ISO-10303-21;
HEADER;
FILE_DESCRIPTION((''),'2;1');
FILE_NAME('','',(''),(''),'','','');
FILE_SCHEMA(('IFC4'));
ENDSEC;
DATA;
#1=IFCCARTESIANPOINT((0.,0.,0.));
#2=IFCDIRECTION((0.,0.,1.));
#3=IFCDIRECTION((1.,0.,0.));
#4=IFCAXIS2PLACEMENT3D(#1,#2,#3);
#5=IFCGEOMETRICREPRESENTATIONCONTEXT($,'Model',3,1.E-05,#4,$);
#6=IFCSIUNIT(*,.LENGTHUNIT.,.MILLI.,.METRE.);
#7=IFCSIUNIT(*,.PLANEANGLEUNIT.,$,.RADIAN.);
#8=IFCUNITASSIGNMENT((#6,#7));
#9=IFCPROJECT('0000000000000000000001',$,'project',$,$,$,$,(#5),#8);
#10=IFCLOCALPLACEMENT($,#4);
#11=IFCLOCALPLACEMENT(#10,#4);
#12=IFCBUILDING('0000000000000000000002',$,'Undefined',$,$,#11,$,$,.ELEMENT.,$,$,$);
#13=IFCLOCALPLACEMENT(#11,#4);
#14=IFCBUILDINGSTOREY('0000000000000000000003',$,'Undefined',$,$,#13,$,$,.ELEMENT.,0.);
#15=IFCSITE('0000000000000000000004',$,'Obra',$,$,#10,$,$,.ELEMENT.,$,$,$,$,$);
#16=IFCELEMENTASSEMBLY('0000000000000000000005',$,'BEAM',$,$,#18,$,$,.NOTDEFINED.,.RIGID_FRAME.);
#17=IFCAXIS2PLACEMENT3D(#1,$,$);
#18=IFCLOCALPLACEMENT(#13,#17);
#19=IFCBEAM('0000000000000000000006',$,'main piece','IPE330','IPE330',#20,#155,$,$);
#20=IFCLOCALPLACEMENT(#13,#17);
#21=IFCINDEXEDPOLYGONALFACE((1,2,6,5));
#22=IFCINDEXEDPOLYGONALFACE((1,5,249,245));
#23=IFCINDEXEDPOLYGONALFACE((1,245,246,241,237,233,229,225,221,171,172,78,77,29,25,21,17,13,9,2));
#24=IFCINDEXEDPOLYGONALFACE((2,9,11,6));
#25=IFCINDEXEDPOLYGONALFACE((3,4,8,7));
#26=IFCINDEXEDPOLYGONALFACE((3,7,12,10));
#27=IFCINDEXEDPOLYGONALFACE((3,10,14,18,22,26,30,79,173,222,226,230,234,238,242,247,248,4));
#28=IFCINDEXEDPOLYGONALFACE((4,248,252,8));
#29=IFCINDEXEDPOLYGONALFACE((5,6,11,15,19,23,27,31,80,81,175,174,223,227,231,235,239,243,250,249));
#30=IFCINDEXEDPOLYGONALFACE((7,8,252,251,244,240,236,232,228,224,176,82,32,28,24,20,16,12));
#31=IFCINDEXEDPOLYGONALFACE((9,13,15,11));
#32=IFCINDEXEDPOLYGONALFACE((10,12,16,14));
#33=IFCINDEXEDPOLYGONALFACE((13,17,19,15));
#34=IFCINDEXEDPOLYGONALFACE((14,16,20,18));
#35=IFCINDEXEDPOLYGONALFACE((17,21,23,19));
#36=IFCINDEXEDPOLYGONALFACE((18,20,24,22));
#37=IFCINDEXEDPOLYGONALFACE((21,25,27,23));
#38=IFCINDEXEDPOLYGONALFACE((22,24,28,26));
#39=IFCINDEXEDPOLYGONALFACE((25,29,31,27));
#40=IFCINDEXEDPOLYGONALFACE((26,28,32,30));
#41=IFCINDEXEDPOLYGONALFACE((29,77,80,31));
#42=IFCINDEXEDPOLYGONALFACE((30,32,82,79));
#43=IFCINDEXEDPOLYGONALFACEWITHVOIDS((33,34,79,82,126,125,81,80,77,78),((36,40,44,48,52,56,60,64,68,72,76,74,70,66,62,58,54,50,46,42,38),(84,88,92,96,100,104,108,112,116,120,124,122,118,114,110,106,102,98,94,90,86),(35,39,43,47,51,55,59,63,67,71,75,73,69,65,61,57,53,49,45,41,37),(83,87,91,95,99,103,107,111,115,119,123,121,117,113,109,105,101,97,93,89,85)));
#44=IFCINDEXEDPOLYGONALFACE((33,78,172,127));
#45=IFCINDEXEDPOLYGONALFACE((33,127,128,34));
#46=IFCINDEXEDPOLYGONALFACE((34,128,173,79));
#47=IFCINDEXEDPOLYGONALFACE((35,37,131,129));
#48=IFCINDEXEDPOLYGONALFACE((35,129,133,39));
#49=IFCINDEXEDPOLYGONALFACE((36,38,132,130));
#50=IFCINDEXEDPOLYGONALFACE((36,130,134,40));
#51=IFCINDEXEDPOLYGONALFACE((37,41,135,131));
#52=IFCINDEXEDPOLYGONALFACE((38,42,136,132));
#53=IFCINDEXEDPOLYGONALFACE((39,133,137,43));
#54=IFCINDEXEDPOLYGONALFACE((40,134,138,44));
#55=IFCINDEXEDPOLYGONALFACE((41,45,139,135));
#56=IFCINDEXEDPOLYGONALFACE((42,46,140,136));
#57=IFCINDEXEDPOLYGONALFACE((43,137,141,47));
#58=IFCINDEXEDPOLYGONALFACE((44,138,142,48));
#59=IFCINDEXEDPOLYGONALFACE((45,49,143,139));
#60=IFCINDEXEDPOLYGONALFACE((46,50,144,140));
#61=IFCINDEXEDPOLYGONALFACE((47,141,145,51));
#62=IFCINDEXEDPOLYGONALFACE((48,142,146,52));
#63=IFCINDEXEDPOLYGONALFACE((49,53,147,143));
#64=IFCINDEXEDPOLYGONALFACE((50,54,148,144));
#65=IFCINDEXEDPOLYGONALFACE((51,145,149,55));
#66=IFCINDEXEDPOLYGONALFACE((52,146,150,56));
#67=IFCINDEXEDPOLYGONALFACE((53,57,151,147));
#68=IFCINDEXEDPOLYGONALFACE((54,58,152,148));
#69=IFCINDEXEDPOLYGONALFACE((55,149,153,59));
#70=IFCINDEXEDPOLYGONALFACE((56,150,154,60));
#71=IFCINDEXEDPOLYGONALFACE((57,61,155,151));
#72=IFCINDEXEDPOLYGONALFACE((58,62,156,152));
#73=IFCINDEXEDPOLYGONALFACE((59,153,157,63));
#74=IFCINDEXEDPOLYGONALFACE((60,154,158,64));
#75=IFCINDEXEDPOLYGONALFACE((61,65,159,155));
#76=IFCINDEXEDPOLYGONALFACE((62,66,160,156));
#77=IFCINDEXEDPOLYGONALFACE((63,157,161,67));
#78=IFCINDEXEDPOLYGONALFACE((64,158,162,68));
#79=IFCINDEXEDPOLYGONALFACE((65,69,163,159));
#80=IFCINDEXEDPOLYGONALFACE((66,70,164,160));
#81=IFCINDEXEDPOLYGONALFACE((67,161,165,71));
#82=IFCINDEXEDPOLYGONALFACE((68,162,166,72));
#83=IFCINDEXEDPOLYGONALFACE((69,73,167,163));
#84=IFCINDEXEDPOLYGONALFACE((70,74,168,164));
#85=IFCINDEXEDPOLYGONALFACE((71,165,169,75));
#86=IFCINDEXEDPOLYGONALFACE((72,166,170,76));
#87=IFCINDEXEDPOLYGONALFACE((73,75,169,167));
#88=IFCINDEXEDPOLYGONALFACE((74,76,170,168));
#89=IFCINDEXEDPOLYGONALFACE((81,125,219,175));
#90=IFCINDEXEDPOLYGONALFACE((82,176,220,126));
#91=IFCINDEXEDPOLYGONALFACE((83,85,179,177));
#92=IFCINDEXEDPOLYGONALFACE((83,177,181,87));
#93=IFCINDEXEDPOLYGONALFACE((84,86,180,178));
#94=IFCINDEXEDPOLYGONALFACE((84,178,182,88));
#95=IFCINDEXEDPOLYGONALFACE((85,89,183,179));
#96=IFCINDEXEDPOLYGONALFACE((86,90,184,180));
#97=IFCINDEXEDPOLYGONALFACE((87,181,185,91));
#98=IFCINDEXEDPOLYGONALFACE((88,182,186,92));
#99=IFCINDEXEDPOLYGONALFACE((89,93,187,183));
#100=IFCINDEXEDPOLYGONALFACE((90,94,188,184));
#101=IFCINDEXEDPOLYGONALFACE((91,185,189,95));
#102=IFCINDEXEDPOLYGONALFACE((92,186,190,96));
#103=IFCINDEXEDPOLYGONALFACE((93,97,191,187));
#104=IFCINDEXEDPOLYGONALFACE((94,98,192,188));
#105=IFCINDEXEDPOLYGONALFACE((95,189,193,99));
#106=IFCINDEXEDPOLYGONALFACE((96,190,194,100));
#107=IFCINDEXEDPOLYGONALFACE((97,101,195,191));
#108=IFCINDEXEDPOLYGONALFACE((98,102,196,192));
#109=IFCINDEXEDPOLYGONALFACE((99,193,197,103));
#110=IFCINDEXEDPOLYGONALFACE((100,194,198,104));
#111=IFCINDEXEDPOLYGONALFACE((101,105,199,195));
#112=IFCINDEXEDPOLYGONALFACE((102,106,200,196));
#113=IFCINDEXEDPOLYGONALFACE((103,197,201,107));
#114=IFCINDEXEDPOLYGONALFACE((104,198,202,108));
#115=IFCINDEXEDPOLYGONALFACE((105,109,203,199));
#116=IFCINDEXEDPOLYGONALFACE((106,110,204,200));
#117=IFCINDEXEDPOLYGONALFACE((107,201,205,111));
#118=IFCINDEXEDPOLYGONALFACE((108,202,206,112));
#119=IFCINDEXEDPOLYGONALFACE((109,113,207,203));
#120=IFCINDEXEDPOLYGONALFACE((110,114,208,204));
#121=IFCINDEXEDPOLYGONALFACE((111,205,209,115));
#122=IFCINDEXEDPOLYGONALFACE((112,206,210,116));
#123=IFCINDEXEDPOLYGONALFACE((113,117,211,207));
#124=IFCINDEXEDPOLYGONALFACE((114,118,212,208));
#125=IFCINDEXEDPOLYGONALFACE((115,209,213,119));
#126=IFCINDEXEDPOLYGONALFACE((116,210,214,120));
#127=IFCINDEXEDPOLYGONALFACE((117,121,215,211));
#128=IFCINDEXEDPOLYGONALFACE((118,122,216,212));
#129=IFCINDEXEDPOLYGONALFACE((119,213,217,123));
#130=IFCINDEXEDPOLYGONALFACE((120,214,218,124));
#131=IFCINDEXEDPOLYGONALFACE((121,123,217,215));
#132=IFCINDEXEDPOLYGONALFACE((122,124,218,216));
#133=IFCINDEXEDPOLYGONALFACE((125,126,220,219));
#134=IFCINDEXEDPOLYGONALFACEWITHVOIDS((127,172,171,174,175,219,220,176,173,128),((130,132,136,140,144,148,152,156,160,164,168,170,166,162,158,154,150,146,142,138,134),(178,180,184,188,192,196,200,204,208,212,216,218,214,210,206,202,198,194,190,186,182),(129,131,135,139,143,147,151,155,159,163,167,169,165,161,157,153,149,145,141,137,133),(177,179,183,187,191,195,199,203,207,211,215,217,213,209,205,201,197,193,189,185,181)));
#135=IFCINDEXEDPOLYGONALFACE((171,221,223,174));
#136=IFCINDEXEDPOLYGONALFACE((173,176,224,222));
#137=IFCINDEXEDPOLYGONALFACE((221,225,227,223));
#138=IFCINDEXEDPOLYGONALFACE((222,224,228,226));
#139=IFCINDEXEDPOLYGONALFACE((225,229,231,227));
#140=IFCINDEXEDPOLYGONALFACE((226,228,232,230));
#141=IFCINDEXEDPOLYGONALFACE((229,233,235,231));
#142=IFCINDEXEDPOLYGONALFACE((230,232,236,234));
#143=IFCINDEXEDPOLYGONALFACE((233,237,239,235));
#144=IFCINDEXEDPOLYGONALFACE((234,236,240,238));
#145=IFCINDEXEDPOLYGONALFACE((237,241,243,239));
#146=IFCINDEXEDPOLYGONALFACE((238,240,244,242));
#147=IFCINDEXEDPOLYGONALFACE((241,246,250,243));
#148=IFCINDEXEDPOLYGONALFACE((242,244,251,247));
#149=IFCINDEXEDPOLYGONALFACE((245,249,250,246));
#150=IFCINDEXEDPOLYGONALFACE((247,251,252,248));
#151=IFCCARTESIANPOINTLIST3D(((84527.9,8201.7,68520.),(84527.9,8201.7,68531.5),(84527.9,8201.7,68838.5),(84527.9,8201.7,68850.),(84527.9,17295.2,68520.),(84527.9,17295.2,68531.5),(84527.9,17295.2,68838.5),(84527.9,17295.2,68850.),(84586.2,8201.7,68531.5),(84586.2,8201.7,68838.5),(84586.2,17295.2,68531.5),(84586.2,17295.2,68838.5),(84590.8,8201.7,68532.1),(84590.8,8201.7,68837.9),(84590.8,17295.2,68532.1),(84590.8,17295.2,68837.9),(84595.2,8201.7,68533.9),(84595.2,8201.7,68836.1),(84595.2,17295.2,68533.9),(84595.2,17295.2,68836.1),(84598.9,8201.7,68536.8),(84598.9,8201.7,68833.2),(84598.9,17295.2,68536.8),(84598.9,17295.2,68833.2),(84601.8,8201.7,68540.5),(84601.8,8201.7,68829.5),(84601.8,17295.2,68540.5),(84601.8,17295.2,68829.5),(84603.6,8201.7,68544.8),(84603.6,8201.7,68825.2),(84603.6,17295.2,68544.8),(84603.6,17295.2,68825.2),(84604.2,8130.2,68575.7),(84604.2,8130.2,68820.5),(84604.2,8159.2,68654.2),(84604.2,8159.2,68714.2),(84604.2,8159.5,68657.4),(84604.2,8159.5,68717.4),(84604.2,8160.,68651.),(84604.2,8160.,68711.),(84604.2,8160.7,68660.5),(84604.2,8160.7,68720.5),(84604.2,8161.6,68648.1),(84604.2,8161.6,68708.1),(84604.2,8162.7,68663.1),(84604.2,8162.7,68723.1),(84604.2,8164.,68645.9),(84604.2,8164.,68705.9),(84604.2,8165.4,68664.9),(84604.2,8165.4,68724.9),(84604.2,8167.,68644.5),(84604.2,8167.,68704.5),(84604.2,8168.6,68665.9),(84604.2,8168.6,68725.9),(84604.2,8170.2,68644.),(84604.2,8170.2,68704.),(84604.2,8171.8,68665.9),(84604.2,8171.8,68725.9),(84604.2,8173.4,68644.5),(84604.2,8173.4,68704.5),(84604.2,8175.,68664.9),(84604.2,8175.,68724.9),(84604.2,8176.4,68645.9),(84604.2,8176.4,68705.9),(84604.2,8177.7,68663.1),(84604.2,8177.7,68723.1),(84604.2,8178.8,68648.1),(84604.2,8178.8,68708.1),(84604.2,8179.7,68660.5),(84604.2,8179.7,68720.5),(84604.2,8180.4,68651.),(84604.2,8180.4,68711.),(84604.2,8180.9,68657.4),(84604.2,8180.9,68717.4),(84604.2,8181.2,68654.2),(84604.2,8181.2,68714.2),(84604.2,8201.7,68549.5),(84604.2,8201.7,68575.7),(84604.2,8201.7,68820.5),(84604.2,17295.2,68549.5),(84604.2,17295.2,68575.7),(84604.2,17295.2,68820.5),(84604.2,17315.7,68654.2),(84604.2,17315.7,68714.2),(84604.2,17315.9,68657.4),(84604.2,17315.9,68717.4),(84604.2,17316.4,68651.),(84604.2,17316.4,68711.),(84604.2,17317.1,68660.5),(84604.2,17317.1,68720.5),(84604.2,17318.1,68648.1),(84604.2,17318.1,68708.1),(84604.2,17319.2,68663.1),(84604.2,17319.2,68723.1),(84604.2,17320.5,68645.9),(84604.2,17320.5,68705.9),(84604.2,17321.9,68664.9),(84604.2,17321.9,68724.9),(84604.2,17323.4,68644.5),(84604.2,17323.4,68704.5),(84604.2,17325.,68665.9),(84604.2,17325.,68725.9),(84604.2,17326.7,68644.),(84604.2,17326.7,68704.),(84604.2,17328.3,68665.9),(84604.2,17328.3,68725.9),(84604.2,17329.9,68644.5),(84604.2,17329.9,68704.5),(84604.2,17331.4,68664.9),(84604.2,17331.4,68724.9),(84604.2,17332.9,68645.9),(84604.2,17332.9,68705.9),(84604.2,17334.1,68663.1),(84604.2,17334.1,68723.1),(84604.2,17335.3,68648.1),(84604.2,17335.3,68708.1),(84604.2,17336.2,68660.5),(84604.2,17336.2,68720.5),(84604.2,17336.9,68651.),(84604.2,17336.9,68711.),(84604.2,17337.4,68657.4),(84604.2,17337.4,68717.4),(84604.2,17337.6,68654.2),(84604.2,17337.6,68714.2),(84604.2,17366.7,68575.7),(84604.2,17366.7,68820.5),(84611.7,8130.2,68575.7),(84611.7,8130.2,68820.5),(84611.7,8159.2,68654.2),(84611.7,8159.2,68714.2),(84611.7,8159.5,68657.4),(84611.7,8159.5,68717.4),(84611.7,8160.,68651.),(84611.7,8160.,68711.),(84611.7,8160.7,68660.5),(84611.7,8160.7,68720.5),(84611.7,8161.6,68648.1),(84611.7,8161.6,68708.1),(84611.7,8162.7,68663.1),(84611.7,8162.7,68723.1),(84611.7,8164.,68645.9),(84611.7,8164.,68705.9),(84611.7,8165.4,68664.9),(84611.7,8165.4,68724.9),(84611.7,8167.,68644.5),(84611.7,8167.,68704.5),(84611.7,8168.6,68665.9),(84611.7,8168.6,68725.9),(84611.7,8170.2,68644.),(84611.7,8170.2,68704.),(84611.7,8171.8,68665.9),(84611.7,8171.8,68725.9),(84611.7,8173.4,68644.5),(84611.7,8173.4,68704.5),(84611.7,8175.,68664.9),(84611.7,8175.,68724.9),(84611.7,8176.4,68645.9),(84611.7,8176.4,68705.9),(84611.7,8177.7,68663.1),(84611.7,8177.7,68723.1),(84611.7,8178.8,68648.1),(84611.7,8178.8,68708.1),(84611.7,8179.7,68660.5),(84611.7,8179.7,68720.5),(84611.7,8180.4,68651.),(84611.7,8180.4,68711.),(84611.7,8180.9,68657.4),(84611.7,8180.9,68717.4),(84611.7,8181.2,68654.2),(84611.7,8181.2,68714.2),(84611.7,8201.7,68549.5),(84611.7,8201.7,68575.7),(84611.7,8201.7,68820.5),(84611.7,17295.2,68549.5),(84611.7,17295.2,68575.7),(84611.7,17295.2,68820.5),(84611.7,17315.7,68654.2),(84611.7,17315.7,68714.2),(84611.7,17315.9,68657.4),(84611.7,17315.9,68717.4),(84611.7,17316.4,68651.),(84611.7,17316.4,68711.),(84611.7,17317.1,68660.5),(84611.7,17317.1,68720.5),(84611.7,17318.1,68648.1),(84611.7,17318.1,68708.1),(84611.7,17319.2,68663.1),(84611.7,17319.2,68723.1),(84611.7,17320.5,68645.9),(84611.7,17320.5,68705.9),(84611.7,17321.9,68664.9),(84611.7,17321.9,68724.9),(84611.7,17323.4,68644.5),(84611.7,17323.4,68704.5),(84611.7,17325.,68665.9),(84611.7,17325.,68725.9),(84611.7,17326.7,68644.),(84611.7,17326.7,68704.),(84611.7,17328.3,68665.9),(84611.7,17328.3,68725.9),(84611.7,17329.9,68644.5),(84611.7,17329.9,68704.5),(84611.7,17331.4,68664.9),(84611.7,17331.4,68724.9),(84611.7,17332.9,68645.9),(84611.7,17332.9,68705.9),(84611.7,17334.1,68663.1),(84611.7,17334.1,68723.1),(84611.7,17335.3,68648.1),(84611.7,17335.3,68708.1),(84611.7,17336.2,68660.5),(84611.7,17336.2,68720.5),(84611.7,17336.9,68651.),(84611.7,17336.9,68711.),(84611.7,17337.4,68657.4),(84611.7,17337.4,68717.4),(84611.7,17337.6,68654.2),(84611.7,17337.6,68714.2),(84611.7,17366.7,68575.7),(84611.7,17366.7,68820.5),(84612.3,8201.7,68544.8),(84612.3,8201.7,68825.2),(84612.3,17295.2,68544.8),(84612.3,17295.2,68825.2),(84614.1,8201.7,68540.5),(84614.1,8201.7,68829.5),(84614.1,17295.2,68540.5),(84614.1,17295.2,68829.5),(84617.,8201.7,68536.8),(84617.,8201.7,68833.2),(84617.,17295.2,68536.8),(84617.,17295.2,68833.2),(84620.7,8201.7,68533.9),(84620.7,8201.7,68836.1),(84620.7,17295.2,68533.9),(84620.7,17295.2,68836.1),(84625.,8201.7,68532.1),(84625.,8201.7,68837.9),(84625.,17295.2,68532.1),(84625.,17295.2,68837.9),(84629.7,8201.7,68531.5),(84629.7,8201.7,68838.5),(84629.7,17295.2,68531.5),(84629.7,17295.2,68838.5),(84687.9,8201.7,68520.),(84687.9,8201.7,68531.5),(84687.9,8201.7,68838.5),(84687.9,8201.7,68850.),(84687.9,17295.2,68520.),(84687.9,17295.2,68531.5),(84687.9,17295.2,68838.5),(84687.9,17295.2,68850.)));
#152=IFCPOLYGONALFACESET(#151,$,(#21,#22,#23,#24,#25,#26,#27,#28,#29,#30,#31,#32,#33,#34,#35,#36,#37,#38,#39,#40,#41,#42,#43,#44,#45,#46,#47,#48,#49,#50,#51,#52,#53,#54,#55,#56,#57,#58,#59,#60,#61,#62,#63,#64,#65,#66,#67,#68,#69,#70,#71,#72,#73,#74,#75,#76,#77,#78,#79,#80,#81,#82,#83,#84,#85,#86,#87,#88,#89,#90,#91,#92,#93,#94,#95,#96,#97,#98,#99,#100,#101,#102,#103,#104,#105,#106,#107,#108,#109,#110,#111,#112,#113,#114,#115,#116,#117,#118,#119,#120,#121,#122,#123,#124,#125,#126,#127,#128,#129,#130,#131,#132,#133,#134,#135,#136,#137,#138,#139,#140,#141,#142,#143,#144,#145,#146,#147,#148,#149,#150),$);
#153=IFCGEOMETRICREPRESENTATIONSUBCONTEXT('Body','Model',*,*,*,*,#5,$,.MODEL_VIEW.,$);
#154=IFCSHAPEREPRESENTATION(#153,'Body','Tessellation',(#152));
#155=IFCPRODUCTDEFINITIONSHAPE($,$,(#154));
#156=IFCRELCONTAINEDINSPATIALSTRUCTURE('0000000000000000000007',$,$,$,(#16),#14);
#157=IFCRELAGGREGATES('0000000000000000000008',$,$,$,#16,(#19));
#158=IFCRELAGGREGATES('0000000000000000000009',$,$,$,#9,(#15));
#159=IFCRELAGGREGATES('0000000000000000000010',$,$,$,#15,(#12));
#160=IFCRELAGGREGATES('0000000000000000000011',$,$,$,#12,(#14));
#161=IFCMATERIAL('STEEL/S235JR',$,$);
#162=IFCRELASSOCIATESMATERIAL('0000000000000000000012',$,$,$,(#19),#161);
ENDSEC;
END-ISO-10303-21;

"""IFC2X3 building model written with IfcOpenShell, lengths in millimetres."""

from ifc_helpers import new_model, si_unit, frame, origin_with_axes, origin_2d_with_axis, place, context, subcontext, project, spatial, rectangle, circle, i_section, extrude, clip, halfspace, source, transform, mapped, material, element, aggregate, save


model = new_model("IFC2X3")

# Units and contexts
model_context = context("Model", 3, precision=1e-05, world=origin_with_axes())
body_context = subcontext(model_context, "Body", "Model", "MODEL_VIEW")
ifc_project = project(units=[si_unit("LENGTHUNIT", "METRE", prefix="MILLI"), si_unit("PLANEANGLEUNIT", "RADIAN")], contexts=[model_context])

# Site, building, storey
site_placement = place(None, origin_with_axes())
site = spatial("IfcSite", under=ifc_project, at=site_placement, Name="Obra", CompositionType="ELEMENT")
building_placement = place(site_placement, origin_with_axes())
building = spatial("IfcBuilding", under=site, at=building_placement, Name="Undefined", CompositionType="ELEMENT")
storey_placement = place(building_placement, origin_with_axes())
storey = spatial("IfcBuildingStorey", under=building, at=storey_placement, Name="Undefined", CompositionType="ELEMENT", Elevation=0.0)

# Shared definitions
ifc_material = material(Name="STEEL/S235JR")

# Element assembly, beam, openings
assembly_1_placement = place(storey_placement, origin_with_axes())
assembly_1 = element("IfcElementAssembly", 1, at=assembly_1_placement, inside=storey, Name="BEAM", AssemblyPlace="NOTDEFINED", PredefinedType="RIGID_FRAME")
beam_1_placement = place(assembly_1_placement, frame((84607.9, 8215.2, 68685.0), z_axis=(0.0, 0.0, 1.0), x_axis=(0.0, 1.0, 0.0)))
beam_1 = element("IfcBeam", 2, at=beam_1_placement, material=ifc_material, Name="main piece", Description="IPE330", ObjectType="IPE330", context=body_context, shape_type="Clipping", body=[
    clip(clip(extrude(i_section(OverallWidth=160.0, OverallDepth=330.0, WebThickness=7.5, FlangeThickness=11.5, FilletRadius=18.0, at=origin_2d_with_axis()), frame((9151.5, 0.0, 0.0), z_axis=(-1.0, 0.0, 0.0), x_axis=(0.0, -1.0, 0.0)), (0.0, 0.0, 1.0), 9236.5), halfspace(frame((9151.5, 0.0, -265.0), z_axis=(-1.0, 0.0, 0.0), x_axis=(0.0, 1.0, 0.0)), True)), halfspace(frame((-85.0, 0.0, -265.0), z_axis=(1.0, 0.0, 0.0), x_axis=(0.0, -1.0, 0.0)), True)),
])
opening_1_placement = place(assembly_1_placement, frame((84607.9, 8215.2, 68685.0), z_axis=(0.0, 0.0, 1.0), x_axis=(0.0, 1.0, 0.0)))
element("IfcOpeningElement", 3, at=opening_1_placement, cuts=beam_1, ObjectType="Recess", context=body_context, shape_type="SweptSolid", body=[
    extrude(rectangle(XDim=56.7, YDim=83.5, at=origin_2d_with_axis()), frame((9121.7, 81.0, -137.7), z_axis=(0.0, -1.0, 0.0), x_axis=(0.0, 0.0, -1.0)), (0.0, 0.0, 1.0), 162.0),
])
opening_2_placement = place(assembly_1_placement, frame((84607.9, 8215.2, 68685.0), z_axis=(0.0, 0.0, 1.0), x_axis=(0.0, 1.0, 0.0)))
element("IfcOpeningElement", 4, at=opening_2_placement, cuts=beam_1, ObjectType="Recess", context=body_context, shape_type="SweptSolid", body=[
    extrude(rectangle(XDim=30.5, YDim=83.5, at=origin_2d_with_axis()), frame((9121.7, 81.0, 150.8), z_axis=(0.0, -1.0, 0.0), x_axis=(0.0, 0.0, -1.0)), (0.0, 0.0, 1.0), 162.0),
])
opening_3_placement = place(assembly_1_placement, frame((84607.9, 8215.2, 68685.0), z_axis=(0.0, 0.0, 1.0), x_axis=(0.0, 1.0, 0.0)))
element("IfcOpeningElement", 5, at=opening_3_placement, cuts=beam_1, ObjectType="Recess", context=body_context, shape_type="SweptSolid", body=[
    extrude(rectangle(XDim=56.7, YDim=83.5, at=origin_2d_with_axis()), frame((-55.3, -81.0, -137.7), z_axis=(0.0, 1.0, 0.0), x_axis=(0.0, 0.0, -1.0)), (0.0, 0.0, 1.0), 162.0),
])
opening_4_placement = place(assembly_1_placement, frame((84607.9, 8215.2, 68685.0), z_axis=(0.0, 0.0, 1.0), x_axis=(0.0, 1.0, 0.0)))
element("IfcOpeningElement", 6, at=opening_4_placement, cuts=beam_1, ObjectType="Recess", context=body_context, shape_type="SweptSolid", body=[
    extrude(rectangle(XDim=30.5, YDim=83.5, at=origin_2d_with_axis()), frame((-55.3, -81.0, 150.8), z_axis=(0.0, 1.0, 0.0), x_axis=(0.0, 0.0, -1.0)), (0.0, 0.0, 1.0), 162.0),
])
shared_shape_1 = source(origin_with_axes(), body_context, "Body", "SweptSolid", [
    extrude(circle(Radius=11.0, at=origin_2d_with_axis()), frame((0.0, -3.9, 0.0), z_axis=(0.0, 1.0, 0.0), x_axis=(1.0, 0.0, 0.0)), (0.0, 0.0, 1.0), 7.7),
])
opening_5_placement = place(assembly_1_placement, frame((84607.9, 17366.7, 68850.0), z_axis=(0.0, -1.0, 0.0), x_axis=(0.0, 0.0, -1.0)))
element("IfcOpeningElement", 7, at=opening_5_placement, cuts=beam_1, ObjectType="Opening", context=body_context, shape_type="MappedRepresentation", body=[
    mapped(shared_shape_1, transform((135.0, 0.0, 40.0))),
    mapped(shared_shape_1, transform((195.0, 0.0, 40.0))),
])
opening_6_placement = place(assembly_1_placement, frame((84607.9, 8130.2, 68850.0), z_axis=(0.0, 1.0, 0.0), x_axis=(0.0, 0.0, -1.0)))
element("IfcOpeningElement", 8, at=opening_6_placement, cuts=beam_1, ObjectType="Opening", context=body_context, shape_type="MappedRepresentation", body=[
    mapped(shared_shape_1, transform((135.0, 0.0, 40.0))),
    mapped(shared_shape_1, transform((195.0, 0.0, 40.0))),
])
aggregate(assembly_1, [beam_1])

save(model, "model.ifc")
